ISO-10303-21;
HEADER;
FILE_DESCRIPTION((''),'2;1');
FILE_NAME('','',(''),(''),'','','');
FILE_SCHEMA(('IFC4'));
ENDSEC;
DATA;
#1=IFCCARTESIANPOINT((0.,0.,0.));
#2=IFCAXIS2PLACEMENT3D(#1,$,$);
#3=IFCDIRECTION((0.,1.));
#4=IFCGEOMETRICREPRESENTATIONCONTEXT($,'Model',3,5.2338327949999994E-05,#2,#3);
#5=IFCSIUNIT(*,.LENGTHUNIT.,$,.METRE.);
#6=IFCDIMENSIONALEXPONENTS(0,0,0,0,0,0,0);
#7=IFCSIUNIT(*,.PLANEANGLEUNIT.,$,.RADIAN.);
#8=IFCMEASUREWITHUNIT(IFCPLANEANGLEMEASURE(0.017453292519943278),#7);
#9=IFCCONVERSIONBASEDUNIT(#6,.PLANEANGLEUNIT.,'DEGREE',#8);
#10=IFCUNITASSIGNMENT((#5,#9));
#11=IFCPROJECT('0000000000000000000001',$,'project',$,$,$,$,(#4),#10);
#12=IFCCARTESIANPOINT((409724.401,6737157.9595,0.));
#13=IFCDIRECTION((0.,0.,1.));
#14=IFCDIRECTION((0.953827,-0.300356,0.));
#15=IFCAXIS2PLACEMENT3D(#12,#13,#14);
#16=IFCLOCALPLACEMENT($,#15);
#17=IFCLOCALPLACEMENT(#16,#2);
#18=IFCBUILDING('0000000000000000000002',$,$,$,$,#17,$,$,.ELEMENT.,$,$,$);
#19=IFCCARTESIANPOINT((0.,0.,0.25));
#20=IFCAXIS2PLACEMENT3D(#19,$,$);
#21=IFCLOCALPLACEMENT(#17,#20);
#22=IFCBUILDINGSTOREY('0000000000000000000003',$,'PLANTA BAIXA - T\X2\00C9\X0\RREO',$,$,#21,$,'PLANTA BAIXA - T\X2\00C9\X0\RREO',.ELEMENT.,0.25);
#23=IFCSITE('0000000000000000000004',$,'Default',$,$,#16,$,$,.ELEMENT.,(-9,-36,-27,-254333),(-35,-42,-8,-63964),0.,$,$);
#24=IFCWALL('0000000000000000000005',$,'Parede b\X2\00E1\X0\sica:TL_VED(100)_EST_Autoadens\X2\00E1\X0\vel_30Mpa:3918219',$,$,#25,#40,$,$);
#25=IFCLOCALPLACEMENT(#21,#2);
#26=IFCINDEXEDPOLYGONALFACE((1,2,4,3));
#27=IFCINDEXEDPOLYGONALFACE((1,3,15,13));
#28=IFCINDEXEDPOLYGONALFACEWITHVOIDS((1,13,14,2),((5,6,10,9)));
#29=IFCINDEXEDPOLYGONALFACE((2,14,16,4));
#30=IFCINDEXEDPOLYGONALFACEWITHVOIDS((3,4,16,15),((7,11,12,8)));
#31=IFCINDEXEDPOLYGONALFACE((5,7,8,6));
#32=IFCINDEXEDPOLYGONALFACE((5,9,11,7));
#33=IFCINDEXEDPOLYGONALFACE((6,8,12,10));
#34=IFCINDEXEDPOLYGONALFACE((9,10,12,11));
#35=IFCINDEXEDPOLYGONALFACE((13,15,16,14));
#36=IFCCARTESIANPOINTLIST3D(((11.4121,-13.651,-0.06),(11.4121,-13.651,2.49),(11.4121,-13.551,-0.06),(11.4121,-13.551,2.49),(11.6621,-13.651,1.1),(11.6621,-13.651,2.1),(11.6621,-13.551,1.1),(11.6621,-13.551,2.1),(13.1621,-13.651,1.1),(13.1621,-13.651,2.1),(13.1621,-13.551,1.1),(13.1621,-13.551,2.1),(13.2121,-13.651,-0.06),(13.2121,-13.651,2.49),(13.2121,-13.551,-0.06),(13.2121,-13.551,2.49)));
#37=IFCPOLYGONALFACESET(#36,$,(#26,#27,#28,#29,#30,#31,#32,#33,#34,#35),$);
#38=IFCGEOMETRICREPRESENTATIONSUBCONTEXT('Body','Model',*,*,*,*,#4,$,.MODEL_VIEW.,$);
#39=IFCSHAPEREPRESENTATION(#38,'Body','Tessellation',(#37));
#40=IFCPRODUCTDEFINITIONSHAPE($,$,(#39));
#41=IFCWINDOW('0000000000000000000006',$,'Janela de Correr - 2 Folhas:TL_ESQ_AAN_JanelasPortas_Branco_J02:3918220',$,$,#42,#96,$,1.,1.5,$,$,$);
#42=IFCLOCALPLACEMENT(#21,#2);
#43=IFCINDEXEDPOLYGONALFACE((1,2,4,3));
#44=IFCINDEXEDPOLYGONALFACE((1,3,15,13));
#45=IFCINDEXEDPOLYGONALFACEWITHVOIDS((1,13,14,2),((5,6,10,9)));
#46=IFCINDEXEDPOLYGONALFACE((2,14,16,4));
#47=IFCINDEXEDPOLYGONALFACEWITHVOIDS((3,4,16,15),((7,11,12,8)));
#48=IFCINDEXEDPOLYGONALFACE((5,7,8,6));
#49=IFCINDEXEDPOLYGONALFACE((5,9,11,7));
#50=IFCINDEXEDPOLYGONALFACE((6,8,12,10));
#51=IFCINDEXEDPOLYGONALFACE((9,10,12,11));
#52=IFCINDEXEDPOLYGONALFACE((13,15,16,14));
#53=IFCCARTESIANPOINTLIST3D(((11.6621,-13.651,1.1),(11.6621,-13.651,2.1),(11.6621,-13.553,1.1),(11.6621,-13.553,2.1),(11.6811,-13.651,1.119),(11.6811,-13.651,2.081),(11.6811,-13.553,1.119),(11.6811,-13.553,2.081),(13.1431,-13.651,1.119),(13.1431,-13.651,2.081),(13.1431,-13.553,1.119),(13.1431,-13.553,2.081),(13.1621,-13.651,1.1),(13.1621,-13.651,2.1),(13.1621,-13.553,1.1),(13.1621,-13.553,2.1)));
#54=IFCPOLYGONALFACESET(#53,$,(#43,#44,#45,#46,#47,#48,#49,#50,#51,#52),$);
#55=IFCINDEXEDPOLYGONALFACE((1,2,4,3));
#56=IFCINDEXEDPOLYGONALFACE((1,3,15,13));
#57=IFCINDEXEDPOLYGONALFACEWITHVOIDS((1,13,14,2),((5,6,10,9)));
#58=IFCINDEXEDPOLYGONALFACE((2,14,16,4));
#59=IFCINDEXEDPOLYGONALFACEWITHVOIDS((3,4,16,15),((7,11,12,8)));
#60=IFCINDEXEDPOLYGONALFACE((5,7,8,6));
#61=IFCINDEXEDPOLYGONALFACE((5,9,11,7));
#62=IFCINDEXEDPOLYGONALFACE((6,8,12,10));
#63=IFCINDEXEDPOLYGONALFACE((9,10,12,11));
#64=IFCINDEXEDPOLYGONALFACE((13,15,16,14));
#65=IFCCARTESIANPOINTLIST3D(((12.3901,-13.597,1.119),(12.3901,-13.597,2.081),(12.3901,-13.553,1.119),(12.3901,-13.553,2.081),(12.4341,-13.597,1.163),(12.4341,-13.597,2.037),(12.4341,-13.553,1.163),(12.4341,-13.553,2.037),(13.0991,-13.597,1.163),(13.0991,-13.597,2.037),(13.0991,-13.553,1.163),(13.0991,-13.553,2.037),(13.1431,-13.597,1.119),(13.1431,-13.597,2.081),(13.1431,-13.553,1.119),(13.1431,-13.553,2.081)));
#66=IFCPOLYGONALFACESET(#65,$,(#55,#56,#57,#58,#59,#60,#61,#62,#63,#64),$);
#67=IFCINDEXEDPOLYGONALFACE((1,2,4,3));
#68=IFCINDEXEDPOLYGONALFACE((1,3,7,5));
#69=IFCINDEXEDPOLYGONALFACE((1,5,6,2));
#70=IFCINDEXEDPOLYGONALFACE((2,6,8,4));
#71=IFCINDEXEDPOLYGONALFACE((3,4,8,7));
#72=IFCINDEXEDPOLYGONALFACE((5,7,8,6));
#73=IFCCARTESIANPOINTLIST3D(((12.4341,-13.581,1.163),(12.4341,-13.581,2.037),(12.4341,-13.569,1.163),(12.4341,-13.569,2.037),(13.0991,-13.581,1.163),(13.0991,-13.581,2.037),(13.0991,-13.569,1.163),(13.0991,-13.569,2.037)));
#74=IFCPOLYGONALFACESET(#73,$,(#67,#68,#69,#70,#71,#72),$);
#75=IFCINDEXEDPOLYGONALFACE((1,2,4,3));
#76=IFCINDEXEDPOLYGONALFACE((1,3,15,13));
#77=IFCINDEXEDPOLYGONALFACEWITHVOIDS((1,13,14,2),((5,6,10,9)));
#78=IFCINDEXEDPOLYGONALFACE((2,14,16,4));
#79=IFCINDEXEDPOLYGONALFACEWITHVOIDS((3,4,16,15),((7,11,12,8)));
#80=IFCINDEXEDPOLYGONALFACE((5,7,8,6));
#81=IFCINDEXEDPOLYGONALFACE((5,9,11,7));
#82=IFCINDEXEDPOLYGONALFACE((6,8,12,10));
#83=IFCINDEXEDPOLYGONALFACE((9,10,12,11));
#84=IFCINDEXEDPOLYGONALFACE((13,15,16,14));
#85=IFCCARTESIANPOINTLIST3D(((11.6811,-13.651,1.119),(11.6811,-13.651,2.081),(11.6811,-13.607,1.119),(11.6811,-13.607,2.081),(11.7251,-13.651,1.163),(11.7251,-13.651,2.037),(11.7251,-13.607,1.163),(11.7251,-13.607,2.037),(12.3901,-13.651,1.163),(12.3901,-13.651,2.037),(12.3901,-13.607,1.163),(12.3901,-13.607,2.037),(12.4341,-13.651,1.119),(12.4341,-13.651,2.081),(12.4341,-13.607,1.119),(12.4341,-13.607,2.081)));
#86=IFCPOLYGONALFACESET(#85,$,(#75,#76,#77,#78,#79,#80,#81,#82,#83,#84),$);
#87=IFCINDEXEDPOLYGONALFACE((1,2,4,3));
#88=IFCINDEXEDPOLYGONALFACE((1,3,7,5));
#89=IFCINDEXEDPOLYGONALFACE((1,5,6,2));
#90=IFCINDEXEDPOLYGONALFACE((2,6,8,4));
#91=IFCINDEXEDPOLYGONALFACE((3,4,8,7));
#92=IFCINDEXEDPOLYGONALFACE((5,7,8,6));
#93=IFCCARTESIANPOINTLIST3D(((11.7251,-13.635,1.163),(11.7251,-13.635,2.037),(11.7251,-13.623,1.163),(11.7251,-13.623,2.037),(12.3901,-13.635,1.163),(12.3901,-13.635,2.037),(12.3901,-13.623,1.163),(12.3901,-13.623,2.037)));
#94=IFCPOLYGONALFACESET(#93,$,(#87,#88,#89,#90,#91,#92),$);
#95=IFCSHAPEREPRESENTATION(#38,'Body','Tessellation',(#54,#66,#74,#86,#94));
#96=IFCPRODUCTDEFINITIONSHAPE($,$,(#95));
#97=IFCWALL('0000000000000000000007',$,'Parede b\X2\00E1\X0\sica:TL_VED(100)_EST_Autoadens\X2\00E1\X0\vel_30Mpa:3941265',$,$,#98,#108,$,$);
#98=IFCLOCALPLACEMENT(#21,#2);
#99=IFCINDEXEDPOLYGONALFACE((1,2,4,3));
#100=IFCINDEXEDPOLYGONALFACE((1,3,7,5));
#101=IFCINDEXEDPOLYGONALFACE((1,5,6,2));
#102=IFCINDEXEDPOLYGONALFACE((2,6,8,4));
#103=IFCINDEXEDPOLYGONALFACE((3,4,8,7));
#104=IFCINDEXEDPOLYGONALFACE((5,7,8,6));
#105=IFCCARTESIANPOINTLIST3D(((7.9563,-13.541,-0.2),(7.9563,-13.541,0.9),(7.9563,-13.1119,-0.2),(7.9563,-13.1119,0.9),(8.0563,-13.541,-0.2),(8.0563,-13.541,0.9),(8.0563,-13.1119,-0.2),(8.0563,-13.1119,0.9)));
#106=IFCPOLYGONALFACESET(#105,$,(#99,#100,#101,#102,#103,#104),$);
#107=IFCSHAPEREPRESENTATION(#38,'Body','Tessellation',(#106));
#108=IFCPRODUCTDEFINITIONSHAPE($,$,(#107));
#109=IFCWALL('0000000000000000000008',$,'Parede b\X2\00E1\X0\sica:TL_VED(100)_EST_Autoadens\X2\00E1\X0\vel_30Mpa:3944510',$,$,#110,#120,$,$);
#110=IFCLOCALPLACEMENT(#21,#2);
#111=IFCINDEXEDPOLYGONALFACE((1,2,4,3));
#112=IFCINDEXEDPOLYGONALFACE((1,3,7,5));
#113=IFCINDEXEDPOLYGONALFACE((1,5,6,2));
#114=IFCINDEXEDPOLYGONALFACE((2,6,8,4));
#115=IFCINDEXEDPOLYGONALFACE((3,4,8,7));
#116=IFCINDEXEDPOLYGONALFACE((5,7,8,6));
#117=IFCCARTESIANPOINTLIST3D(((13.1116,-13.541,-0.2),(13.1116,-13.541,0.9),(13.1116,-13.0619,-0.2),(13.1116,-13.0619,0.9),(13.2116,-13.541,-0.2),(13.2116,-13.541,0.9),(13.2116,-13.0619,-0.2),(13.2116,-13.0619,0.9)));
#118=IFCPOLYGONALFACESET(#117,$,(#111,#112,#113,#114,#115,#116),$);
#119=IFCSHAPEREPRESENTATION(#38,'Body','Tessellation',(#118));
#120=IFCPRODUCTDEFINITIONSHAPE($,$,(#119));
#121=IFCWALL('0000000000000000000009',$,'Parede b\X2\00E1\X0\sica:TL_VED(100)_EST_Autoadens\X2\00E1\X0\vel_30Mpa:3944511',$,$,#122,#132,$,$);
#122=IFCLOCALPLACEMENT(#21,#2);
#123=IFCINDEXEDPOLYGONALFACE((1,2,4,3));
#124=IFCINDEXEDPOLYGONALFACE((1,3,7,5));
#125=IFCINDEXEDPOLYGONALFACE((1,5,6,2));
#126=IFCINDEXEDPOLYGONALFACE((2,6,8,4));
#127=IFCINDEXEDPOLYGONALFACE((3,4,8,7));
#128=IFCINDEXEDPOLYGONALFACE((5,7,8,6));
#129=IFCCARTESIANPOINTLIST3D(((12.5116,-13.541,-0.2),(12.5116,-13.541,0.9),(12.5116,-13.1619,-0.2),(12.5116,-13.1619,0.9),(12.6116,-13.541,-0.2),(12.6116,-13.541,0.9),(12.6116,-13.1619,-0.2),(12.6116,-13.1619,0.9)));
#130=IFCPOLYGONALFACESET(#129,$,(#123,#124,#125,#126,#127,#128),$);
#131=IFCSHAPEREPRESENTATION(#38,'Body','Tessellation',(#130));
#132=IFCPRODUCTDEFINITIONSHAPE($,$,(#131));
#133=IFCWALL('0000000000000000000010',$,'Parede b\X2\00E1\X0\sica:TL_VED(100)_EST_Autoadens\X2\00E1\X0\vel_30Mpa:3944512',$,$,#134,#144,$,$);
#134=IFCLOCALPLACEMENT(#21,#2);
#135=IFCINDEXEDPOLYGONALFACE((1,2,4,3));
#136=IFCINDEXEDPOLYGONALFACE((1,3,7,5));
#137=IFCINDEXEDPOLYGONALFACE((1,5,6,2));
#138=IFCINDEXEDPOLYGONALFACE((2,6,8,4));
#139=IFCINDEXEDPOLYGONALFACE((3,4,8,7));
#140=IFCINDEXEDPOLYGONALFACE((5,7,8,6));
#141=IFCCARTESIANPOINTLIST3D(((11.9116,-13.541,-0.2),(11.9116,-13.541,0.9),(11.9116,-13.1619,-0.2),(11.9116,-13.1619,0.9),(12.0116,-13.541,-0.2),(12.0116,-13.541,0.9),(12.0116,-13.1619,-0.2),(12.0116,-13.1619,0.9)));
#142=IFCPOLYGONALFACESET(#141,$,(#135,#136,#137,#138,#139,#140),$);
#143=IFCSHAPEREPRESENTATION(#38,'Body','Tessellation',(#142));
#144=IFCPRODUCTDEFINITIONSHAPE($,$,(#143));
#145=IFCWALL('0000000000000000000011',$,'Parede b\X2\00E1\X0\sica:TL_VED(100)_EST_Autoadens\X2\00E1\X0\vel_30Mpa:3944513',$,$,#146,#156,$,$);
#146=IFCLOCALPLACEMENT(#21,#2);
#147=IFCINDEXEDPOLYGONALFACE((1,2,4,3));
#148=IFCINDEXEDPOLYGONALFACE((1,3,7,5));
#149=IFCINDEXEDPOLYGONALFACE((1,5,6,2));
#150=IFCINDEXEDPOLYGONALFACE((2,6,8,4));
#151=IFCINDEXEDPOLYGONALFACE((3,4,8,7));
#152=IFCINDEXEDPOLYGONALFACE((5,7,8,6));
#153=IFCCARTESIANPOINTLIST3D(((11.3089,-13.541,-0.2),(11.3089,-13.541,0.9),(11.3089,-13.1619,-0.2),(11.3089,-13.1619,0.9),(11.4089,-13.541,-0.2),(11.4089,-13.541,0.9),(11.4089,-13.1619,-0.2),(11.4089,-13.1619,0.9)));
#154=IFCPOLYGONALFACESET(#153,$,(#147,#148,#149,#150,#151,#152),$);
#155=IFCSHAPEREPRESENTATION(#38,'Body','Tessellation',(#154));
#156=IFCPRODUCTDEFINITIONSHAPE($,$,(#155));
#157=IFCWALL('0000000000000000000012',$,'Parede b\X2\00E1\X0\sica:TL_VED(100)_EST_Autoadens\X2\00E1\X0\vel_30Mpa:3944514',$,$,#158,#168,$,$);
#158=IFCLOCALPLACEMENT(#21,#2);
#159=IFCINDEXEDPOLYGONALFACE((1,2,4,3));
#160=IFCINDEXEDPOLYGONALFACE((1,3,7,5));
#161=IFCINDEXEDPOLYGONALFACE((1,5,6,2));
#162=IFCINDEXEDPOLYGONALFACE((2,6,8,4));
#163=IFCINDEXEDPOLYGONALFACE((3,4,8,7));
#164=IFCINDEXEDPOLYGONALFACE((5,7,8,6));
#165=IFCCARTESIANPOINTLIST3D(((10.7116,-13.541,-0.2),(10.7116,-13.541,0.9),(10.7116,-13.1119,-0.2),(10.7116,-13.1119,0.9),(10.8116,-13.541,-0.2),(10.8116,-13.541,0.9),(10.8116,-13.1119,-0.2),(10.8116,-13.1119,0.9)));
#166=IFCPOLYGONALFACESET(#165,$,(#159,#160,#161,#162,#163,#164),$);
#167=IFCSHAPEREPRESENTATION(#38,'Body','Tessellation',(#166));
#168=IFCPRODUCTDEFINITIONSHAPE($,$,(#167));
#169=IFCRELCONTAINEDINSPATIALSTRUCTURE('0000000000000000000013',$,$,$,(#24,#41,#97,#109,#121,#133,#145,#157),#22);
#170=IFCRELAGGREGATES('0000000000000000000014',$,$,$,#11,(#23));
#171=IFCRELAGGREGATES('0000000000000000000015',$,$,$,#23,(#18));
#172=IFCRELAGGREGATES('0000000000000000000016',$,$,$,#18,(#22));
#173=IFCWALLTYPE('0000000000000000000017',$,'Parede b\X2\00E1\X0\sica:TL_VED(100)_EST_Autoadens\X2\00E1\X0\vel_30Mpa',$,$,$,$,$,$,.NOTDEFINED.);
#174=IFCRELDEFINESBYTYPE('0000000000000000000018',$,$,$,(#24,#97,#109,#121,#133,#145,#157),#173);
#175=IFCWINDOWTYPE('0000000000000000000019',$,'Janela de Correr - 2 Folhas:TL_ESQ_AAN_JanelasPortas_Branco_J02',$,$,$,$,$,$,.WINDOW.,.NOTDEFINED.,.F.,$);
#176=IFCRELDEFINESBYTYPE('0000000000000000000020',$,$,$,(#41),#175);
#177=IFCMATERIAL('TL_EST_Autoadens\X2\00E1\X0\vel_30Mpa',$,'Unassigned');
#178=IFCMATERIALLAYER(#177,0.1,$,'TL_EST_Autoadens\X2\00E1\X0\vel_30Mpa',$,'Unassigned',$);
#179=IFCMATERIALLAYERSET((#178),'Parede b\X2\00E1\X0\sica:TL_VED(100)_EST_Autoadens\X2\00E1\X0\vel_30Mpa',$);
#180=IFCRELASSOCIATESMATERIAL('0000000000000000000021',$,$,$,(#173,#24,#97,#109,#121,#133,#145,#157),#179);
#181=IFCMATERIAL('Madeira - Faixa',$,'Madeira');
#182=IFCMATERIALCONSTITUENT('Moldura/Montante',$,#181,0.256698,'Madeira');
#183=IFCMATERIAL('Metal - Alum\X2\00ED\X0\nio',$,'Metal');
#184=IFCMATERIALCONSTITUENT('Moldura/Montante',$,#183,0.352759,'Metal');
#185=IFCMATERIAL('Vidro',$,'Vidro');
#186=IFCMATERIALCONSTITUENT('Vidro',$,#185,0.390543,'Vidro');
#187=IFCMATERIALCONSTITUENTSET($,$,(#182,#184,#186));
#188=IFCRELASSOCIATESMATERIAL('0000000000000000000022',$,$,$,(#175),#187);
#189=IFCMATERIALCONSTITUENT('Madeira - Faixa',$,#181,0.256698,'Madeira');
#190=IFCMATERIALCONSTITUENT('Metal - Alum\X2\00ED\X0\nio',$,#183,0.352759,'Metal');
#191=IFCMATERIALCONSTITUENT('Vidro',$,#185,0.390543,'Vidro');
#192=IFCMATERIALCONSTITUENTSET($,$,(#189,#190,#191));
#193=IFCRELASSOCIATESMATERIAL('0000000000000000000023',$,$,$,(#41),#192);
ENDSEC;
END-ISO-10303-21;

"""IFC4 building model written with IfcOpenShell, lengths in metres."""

from ifc_helpers import new_model, entity, si_unit, converted_unit, direction, frame, frame_2d, origin, origin_2d_with_axis, place, context, subcontext, project, spatial, polyline, rectangle, outline, extrude, clip, bounded_halfspace, source, transform, mapped, material, layer, layer_set, layer_usage, constituent, constituent_set, type_object, type_shapes, element, fill, save


model = new_model("IFC4")

# Units and contexts
model_context = context("Model", 3, precision=5.2338327949999994e-05, world=origin(), true_north=direction((0.0, 1.0)))
body_context = subcontext(model_context, "Body", "Model", "MODEL_VIEW")
ifc_project = project(units=[si_unit("LENGTHUNIT", "METRE"), converted_unit("PLANEANGLEUNIT", "DEGREE", entity("IfcPlaneAngleMeasure", 0.017453292519943278), si_unit("PLANEANGLEUNIT", "RADIAN"), dimensions=[0, 0, 0, 0, 0, 0, 0])], contexts=[model_context])

# Site, building, storey
site_placement = place(None, frame((409724.401, 6737157.9595, 0.0), z_axis=(0.0, 0.0, 1.0), x_axis=(0.953827, -0.300356, 0.0)))
site = spatial("IfcSite", under=ifc_project, at=site_placement, Name="Default", CompositionType="ELEMENT", RefLatitude=(-9, -36, -27, -254333), RefLongitude=(-35, -42, -8, -63964), RefElevation=0.0)
building_placement = place(site_placement, origin())
building = spatial("IfcBuilding", under=site, at=building_placement, CompositionType="ELEMENT")
storey_placement = place(building_placement, frame((0.0, 0.0, 0.25)))
storey = spatial("IfcBuildingStorey", under=building, at=storey_placement, Name="PLANTA BAIXA - TÉRREO", LongName="PLANTA BAIXA - TÉRREO", CompositionType="ELEMENT", Elevation=0.25)

# Shared definitions
ifc_material_1 = material(Name="TL_EST_Autoadensável_30Mpa", Category="Unassigned")
ifc_layer_1 = layer(ifc_material_1, 0.1, Name="TL_EST_Autoadensável_30Mpa", Category="Unassigned")
ifc_layer_set_1 = layer_set([ifc_layer_1], Name="Parede básica:TL_VED(100)_EST_Autoadensável_30Mpa")
wall_type_1 = type_object("IfcWallType", Name="Parede básica:TL_VED(100)_EST_Autoadensável_30Mpa", PredefinedType="NOTDEFINED", material=ifc_layer_set_1)

# Wall, opening, window
ifc_layer_usage_1 = layer_usage(ifc_layer_set_1, "AXIS2", "POSITIVE", -0.05)
wall_1_placement = place(storey_placement, frame((13.2121, -13.601, -0.06), z_axis=(0.0, 0.0, 1.0), x_axis=(-1.0, 0.0, 0.0)))
wall_1 = element("IfcWall", 1, at=wall_1_placement, inside=storey, type_object=wall_type_1, material=ifc_layer_usage_1, Name="Parede básica:TL_VED(100)_EST_Autoadensável_30Mpa:3918219", context=body_context, shape_type="SweptSolid", body=[
    extrude(rectangle(XDim=1.8, YDim=0.1, at=frame_2d((0.9, 0.0), x_axis=(-1.0, 0.0))), origin(), (0.0, 0.0, 1.0), 2.55),
])
opening_1_placement = place(wall_1_placement, frame((1.55, 0.05, 1.16)))
opening_1 = element("IfcOpeningElement", 2, at=opening_1_placement, cuts=wall_1, PredefinedType="OPENING", context=body_context, shape_type="SweptSolid", body=[
    extrude(rectangle(XDim=1.0, YDim=1.5, at=frame_2d((0.5, 0.75), x_axis=(-1.0, 0.0))), frame((0.0, 0.0, 0.0), z_axis=(0.0, -1.0, 0.0), x_axis=(0.0, 0.0, 1.0)), (0.0, 0.0, 1.0), 0.1),
])
ifc_material_2 = material(Name="Madeira - Faixa", Category="Madeira")
ifc_constituent_1 = constituent(ifc_material_2, Name="Madeira - Faixa", Category="Madeira", fraction=0.256698)
ifc_material_3 = material(Name="Metal - Alumínio", Category="Metal")
ifc_constituent_2 = constituent(ifc_material_3, Name="Metal - Alumínio", Category="Metal", fraction=0.352759)
ifc_material_4 = material(Name="Vidro", Category="Vidro")
ifc_constituent_3 = constituent(ifc_material_4, Name="Vidro", Category="Vidro", fraction=0.390543)
ifc_constituent_set_1 = constituent_set(constituents=[ifc_constituent_1, ifc_constituent_2, ifc_constituent_3])
ifc_constituent_4 = constituent(ifc_material_2, Name="Moldura/Montante", Category="Madeira", fraction=0.256698)
ifc_constituent_5 = constituent(ifc_material_3, Name="Moldura/Montante", Category="Metal", fraction=0.352759)
ifc_constituent_6 = constituent(ifc_material_4, Name="Vidro", Category="Vidro", fraction=0.390543)
ifc_constituent_set_2 = constituent_set(constituents=[ifc_constituent_4, ifc_constituent_5, ifc_constituent_6])
window_type = type_object("IfcWindowType", Name="Janela de Correr - 2 Folhas:TL_ESQ_AAN_JanelasPortas_Branco_J02", ParameterTakesPrecedence=False, PartitioningType="NOTDEFINED", PredefinedType="WINDOW", material=ifc_constituent_set_2)
shared_shape_1 = source(origin(), body_context, "Body", "SweptSolid", [
    extrude(outline(polyline([(-0.75, -0.5), (0.75, -0.5), (0.75, 0.5), (-0.75, 0.5), (-0.75, -0.5)]), holes=[polyline([(-0.731, -0.481), (-0.731, 0.481), (0.731, 0.481), (0.731, -0.481), (-0.731, -0.481)])]), frame((0.75, 0.0, 0.5), z_axis=(0.0, 1.0, 0.0), x_axis=(1.0, 0.0, 0.0)), (0.0, 0.0, 1.0), 0.098),
    extrude(outline(polyline([(-0.3765, -0.481), (0.3765, -0.481), (0.3765, 0.481), (-0.3765, 0.481), (-0.3765, -0.481)]), holes=[polyline([(-0.3325, -0.437), (-0.3325, 0.437), (0.3325, 0.437), (0.3325, -0.437), (-0.3325, -0.437)])]), frame((1.1045, 0.054, 0.5), z_axis=(0.0, 1.0, 0.0), x_axis=(1.0, 0.0, 0.0)), (0.0, 0.0, 1.0), 0.044),
    extrude(rectangle(XDim=0.012, YDim=0.665, at=origin_2d_with_axis()), frame((1.1045, 0.076, 0.063), z_axis=(0.0, 0.0, 1.0), x_axis=(0.0, -1.0, 0.0)), (0.0, 0.0, 1.0), 0.874),
    extrude(outline(polyline([(-0.481, -0.3765), (0.481, -0.3765), (0.481, 0.3765), (-0.481, 0.3765), (-0.481, -0.3765)]), holes=[polyline([(-0.437, -0.3325), (-0.437, 0.3325), (0.437, 0.3325), (0.437, -0.3325), (-0.437, -0.3325)])]), frame((0.3955, 0.0, 0.5), z_axis=(0.0, 1.0, 0.0), x_axis=(0.0, 0.0, -1.0)), (0.0, 0.0, 1.0), 0.044),
    extrude(rectangle(XDim=0.012, YDim=0.665, at=origin_2d_with_axis()), frame((0.3955, 0.022, 0.063), z_axis=(0.0, 0.0, 1.0), x_axis=(0.0, -1.0, 0.0)), (0.0, 0.0, 1.0), 0.874),
])
type_shapes(window_type, [shared_shape_1])
window_placement = place(opening_1_placement, frame((0.0, 0.0, 0.0), z_axis=(0.0, 0.0, 1.0), x_axis=(-1.0, 0.0, 0.0)))
window = element("IfcWindow", 3, at=window_placement, inside=storey, type_object=window_type, material=ifc_constituent_set_1, Name="Janela de Correr - 2 Folhas:TL_ESQ_AAN_JanelasPortas_Branco_J02:3918220", OverallHeight=1.0, OverallWidth=1.5, context=body_context, shape_type="MappedRepresentation", body=[
    mapped(shared_shape_1, transform((0.0, 0.0, 0.0), scale=1.0)),
])
fill(opening_1, window)

# Walls
ifc_layer_usage_2 = layer_usage(ifc_layer_set_1, "AXIS2", "NEGATIVE", 0.05)
wall_2_placement = place(storey_placement, frame((8.0063, -13.1119, -0.2), z_axis=(0.0, 0.0, 1.0), x_axis=(0.0, -1.0, 0.0)))
element("IfcWall", 4, at=wall_2_placement, inside=storey, type_object=wall_type_1, material=ifc_layer_usage_2, Name="Parede básica:TL_VED(100)_EST_Autoadensável_30Mpa:3941265", context=body_context, shape_type="Clipping", body=[
    clip(extrude(rectangle(XDim=0.4291, YDim=0.1, at=frame_2d((0.2145, 0.0), x_axis=(-1.0, 0.0))), origin(), (0.0, 0.0, 1.0), 1.1), bounded_halfspace(frame((0.0, -0.05, 1.1), z_axis=(0.0, 0.0, -1.0), x_axis=(1.0, 0.0, 0.0)), True, frame((0.0, -0.05, 1.1)), polyline([(0.0, 0.0), (0.05, 0.0), (0.4291, 0.0), (0.4291, 0.1), (0.0, 0.1), (0.0, 0.0)]))),
])
ifc_layer_usage_3 = layer_usage(ifc_layer_set_1, "AXIS2", "POSITIVE", -0.05)
wall_3_placement = place(storey_placement, frame((13.1616, -13.0619, -0.2), z_axis=(0.0, 0.0, 1.0), x_axis=(0.0, -1.0, 0.0)))
element("IfcWall", 5, at=wall_3_placement, inside=storey, type_object=wall_type_1, material=ifc_layer_usage_3, Name="Parede básica:TL_VED(100)_EST_Autoadensável_30Mpa:3944510", context=body_context, shape_type="Clipping", body=[
    clip(extrude(rectangle(XDim=0.4791, YDim=0.1, at=frame_2d((0.2395, 0.0), x_axis=(-1.0, 0.0))), origin(), (0.0, 0.0, 1.0), 1.1), bounded_halfspace(frame((0.0, -0.05, 1.1), z_axis=(0.0, 0.0, -1.0), x_axis=(0.0, 1.0, 0.0)), True, frame((0.0, -0.05, 1.1)), polyline([(0.0, 0.0), (0.1, 0.0), (0.4791, 0.0), (0.4791, 0.1), (0.0, 0.1), (0.0, 0.0)]))),
])
ifc_layer_usage_4 = layer_usage(ifc_layer_set_1, "AXIS2", "POSITIVE", -0.05)
wall_4_placement = place(storey_placement, frame((12.5616, -13.1619, -0.2), z_axis=(0.0, 0.0, 1.0), x_axis=(0.0, -1.0, 0.0)))
element("IfcWall", 6, at=wall_4_placement, inside=storey, type_object=wall_type_1, material=ifc_layer_usage_4, Name="Parede básica:TL_VED(100)_EST_Autoadensável_30Mpa:3944511", context=body_context, shape_type="Clipping", body=[
    clip(extrude(rectangle(XDim=0.3791, YDim=0.1, at=frame_2d((0.1895, 0.0), x_axis=(-1.0, 0.0))), origin(), (0.0, 0.0, 1.0), 1.1), bounded_halfspace(frame((0.0, -0.05, 1.1), z_axis=(0.0, 0.0, -1.0), x_axis=(0.0, 1.0, 0.0)), True, frame((0.0, -0.05, 1.1)), polyline([(0.0, 0.0), (0.3791, 0.0), (0.3791, 0.1), (0.0, 0.1), (0.0, 0.0)]))),
])
ifc_layer_usage_5 = layer_usage(ifc_layer_set_1, "AXIS2", "POSITIVE", -0.05)
wall_5_placement = place(storey_placement, frame((11.9616, -13.1619, -0.2), z_axis=(0.0, 0.0, 1.0), x_axis=(0.0, -1.0, 0.0)))
element("IfcWall", 7, at=wall_5_placement, inside=storey, type_object=wall_type_1, material=ifc_layer_usage_5, Name="Parede básica:TL_VED(100)_EST_Autoadensável_30Mpa:3944512", context=body_context, shape_type="Clipping", body=[
    clip(extrude(rectangle(XDim=0.3791, YDim=0.1, at=frame_2d((0.1895, 0.0), x_axis=(-1.0, 0.0))), origin(), (0.0, 0.0, 1.0), 1.1), bounded_halfspace(frame((0.0, -0.05, 1.1), z_axis=(0.0, 0.0, -1.0), x_axis=(0.0, 1.0, 0.0)), True, frame((0.0, -0.05, 1.1)), polyline([(0.0, 0.0), (0.3791, 0.0), (0.3791, 0.1), (0.0, 0.1), (0.0, 0.0)]))),
])
ifc_layer_usage_6 = layer_usage(ifc_layer_set_1, "AXIS2", "POSITIVE", -0.05)
wall_6_placement = place(storey_placement, frame((11.3589, -13.1619, -0.2), z_axis=(0.0, 0.0, 1.0), x_axis=(0.0, -1.0, 0.0)))
element("IfcWall", 8, at=wall_6_placement, inside=storey, type_object=wall_type_1, material=ifc_layer_usage_6, Name="Parede básica:TL_VED(100)_EST_Autoadensável_30Mpa:3944513", context=body_context, shape_type="Clipping", body=[
    clip(extrude(rectangle(XDim=0.3791, YDim=0.1, at=frame_2d((0.1895, 0.0), x_axis=(-1.0, 0.0))), origin(), (0.0, 0.0, 1.0), 1.1), bounded_halfspace(frame((0.0, -0.05, 1.1), z_axis=(0.0, 0.0, -1.0), x_axis=(0.0, 1.0, 0.0)), True, frame((0.0, -0.05, 1.1)), polyline([(0.0, 0.0), (0.3791, 0.0), (0.3791, 0.1), (0.0, 0.1), (0.0, 0.0)]))),
])
ifc_layer_usage_7 = layer_usage(ifc_layer_set_1, "AXIS2", "POSITIVE", -0.05)
wall_7_placement = place(storey_placement, frame((10.7616, -13.1119, -0.2), z_axis=(0.0, 0.0, 1.0), x_axis=(0.0, -1.0, 0.0)))
element("IfcWall", 9, at=wall_7_placement, inside=storey, type_object=wall_type_1, material=ifc_layer_usage_7, Name="Parede básica:TL_VED(100)_EST_Autoadensável_30Mpa:3944514", context=body_context, shape_type="Clipping", body=[
    clip(extrude(rectangle(XDim=0.4291, YDim=0.1, at=frame_2d((0.2145, 0.0), x_axis=(-1.0, 0.0))), origin(), (0.0, 0.0, 1.0), 1.1), bounded_halfspace(frame((0.0, -0.05, 1.1), z_axis=(0.0, 0.0, -1.0), x_axis=(0.0, 1.0, 0.0)), True, frame((0.0, -0.05, 1.1)), polyline([(0.0, 0.0), (0.4291, 0.0), (0.4291, 0.1), (0.05, 0.1), (0.0, 0.1), (0.0, 0.0)]))),
])

save(model, "model.ifc")
